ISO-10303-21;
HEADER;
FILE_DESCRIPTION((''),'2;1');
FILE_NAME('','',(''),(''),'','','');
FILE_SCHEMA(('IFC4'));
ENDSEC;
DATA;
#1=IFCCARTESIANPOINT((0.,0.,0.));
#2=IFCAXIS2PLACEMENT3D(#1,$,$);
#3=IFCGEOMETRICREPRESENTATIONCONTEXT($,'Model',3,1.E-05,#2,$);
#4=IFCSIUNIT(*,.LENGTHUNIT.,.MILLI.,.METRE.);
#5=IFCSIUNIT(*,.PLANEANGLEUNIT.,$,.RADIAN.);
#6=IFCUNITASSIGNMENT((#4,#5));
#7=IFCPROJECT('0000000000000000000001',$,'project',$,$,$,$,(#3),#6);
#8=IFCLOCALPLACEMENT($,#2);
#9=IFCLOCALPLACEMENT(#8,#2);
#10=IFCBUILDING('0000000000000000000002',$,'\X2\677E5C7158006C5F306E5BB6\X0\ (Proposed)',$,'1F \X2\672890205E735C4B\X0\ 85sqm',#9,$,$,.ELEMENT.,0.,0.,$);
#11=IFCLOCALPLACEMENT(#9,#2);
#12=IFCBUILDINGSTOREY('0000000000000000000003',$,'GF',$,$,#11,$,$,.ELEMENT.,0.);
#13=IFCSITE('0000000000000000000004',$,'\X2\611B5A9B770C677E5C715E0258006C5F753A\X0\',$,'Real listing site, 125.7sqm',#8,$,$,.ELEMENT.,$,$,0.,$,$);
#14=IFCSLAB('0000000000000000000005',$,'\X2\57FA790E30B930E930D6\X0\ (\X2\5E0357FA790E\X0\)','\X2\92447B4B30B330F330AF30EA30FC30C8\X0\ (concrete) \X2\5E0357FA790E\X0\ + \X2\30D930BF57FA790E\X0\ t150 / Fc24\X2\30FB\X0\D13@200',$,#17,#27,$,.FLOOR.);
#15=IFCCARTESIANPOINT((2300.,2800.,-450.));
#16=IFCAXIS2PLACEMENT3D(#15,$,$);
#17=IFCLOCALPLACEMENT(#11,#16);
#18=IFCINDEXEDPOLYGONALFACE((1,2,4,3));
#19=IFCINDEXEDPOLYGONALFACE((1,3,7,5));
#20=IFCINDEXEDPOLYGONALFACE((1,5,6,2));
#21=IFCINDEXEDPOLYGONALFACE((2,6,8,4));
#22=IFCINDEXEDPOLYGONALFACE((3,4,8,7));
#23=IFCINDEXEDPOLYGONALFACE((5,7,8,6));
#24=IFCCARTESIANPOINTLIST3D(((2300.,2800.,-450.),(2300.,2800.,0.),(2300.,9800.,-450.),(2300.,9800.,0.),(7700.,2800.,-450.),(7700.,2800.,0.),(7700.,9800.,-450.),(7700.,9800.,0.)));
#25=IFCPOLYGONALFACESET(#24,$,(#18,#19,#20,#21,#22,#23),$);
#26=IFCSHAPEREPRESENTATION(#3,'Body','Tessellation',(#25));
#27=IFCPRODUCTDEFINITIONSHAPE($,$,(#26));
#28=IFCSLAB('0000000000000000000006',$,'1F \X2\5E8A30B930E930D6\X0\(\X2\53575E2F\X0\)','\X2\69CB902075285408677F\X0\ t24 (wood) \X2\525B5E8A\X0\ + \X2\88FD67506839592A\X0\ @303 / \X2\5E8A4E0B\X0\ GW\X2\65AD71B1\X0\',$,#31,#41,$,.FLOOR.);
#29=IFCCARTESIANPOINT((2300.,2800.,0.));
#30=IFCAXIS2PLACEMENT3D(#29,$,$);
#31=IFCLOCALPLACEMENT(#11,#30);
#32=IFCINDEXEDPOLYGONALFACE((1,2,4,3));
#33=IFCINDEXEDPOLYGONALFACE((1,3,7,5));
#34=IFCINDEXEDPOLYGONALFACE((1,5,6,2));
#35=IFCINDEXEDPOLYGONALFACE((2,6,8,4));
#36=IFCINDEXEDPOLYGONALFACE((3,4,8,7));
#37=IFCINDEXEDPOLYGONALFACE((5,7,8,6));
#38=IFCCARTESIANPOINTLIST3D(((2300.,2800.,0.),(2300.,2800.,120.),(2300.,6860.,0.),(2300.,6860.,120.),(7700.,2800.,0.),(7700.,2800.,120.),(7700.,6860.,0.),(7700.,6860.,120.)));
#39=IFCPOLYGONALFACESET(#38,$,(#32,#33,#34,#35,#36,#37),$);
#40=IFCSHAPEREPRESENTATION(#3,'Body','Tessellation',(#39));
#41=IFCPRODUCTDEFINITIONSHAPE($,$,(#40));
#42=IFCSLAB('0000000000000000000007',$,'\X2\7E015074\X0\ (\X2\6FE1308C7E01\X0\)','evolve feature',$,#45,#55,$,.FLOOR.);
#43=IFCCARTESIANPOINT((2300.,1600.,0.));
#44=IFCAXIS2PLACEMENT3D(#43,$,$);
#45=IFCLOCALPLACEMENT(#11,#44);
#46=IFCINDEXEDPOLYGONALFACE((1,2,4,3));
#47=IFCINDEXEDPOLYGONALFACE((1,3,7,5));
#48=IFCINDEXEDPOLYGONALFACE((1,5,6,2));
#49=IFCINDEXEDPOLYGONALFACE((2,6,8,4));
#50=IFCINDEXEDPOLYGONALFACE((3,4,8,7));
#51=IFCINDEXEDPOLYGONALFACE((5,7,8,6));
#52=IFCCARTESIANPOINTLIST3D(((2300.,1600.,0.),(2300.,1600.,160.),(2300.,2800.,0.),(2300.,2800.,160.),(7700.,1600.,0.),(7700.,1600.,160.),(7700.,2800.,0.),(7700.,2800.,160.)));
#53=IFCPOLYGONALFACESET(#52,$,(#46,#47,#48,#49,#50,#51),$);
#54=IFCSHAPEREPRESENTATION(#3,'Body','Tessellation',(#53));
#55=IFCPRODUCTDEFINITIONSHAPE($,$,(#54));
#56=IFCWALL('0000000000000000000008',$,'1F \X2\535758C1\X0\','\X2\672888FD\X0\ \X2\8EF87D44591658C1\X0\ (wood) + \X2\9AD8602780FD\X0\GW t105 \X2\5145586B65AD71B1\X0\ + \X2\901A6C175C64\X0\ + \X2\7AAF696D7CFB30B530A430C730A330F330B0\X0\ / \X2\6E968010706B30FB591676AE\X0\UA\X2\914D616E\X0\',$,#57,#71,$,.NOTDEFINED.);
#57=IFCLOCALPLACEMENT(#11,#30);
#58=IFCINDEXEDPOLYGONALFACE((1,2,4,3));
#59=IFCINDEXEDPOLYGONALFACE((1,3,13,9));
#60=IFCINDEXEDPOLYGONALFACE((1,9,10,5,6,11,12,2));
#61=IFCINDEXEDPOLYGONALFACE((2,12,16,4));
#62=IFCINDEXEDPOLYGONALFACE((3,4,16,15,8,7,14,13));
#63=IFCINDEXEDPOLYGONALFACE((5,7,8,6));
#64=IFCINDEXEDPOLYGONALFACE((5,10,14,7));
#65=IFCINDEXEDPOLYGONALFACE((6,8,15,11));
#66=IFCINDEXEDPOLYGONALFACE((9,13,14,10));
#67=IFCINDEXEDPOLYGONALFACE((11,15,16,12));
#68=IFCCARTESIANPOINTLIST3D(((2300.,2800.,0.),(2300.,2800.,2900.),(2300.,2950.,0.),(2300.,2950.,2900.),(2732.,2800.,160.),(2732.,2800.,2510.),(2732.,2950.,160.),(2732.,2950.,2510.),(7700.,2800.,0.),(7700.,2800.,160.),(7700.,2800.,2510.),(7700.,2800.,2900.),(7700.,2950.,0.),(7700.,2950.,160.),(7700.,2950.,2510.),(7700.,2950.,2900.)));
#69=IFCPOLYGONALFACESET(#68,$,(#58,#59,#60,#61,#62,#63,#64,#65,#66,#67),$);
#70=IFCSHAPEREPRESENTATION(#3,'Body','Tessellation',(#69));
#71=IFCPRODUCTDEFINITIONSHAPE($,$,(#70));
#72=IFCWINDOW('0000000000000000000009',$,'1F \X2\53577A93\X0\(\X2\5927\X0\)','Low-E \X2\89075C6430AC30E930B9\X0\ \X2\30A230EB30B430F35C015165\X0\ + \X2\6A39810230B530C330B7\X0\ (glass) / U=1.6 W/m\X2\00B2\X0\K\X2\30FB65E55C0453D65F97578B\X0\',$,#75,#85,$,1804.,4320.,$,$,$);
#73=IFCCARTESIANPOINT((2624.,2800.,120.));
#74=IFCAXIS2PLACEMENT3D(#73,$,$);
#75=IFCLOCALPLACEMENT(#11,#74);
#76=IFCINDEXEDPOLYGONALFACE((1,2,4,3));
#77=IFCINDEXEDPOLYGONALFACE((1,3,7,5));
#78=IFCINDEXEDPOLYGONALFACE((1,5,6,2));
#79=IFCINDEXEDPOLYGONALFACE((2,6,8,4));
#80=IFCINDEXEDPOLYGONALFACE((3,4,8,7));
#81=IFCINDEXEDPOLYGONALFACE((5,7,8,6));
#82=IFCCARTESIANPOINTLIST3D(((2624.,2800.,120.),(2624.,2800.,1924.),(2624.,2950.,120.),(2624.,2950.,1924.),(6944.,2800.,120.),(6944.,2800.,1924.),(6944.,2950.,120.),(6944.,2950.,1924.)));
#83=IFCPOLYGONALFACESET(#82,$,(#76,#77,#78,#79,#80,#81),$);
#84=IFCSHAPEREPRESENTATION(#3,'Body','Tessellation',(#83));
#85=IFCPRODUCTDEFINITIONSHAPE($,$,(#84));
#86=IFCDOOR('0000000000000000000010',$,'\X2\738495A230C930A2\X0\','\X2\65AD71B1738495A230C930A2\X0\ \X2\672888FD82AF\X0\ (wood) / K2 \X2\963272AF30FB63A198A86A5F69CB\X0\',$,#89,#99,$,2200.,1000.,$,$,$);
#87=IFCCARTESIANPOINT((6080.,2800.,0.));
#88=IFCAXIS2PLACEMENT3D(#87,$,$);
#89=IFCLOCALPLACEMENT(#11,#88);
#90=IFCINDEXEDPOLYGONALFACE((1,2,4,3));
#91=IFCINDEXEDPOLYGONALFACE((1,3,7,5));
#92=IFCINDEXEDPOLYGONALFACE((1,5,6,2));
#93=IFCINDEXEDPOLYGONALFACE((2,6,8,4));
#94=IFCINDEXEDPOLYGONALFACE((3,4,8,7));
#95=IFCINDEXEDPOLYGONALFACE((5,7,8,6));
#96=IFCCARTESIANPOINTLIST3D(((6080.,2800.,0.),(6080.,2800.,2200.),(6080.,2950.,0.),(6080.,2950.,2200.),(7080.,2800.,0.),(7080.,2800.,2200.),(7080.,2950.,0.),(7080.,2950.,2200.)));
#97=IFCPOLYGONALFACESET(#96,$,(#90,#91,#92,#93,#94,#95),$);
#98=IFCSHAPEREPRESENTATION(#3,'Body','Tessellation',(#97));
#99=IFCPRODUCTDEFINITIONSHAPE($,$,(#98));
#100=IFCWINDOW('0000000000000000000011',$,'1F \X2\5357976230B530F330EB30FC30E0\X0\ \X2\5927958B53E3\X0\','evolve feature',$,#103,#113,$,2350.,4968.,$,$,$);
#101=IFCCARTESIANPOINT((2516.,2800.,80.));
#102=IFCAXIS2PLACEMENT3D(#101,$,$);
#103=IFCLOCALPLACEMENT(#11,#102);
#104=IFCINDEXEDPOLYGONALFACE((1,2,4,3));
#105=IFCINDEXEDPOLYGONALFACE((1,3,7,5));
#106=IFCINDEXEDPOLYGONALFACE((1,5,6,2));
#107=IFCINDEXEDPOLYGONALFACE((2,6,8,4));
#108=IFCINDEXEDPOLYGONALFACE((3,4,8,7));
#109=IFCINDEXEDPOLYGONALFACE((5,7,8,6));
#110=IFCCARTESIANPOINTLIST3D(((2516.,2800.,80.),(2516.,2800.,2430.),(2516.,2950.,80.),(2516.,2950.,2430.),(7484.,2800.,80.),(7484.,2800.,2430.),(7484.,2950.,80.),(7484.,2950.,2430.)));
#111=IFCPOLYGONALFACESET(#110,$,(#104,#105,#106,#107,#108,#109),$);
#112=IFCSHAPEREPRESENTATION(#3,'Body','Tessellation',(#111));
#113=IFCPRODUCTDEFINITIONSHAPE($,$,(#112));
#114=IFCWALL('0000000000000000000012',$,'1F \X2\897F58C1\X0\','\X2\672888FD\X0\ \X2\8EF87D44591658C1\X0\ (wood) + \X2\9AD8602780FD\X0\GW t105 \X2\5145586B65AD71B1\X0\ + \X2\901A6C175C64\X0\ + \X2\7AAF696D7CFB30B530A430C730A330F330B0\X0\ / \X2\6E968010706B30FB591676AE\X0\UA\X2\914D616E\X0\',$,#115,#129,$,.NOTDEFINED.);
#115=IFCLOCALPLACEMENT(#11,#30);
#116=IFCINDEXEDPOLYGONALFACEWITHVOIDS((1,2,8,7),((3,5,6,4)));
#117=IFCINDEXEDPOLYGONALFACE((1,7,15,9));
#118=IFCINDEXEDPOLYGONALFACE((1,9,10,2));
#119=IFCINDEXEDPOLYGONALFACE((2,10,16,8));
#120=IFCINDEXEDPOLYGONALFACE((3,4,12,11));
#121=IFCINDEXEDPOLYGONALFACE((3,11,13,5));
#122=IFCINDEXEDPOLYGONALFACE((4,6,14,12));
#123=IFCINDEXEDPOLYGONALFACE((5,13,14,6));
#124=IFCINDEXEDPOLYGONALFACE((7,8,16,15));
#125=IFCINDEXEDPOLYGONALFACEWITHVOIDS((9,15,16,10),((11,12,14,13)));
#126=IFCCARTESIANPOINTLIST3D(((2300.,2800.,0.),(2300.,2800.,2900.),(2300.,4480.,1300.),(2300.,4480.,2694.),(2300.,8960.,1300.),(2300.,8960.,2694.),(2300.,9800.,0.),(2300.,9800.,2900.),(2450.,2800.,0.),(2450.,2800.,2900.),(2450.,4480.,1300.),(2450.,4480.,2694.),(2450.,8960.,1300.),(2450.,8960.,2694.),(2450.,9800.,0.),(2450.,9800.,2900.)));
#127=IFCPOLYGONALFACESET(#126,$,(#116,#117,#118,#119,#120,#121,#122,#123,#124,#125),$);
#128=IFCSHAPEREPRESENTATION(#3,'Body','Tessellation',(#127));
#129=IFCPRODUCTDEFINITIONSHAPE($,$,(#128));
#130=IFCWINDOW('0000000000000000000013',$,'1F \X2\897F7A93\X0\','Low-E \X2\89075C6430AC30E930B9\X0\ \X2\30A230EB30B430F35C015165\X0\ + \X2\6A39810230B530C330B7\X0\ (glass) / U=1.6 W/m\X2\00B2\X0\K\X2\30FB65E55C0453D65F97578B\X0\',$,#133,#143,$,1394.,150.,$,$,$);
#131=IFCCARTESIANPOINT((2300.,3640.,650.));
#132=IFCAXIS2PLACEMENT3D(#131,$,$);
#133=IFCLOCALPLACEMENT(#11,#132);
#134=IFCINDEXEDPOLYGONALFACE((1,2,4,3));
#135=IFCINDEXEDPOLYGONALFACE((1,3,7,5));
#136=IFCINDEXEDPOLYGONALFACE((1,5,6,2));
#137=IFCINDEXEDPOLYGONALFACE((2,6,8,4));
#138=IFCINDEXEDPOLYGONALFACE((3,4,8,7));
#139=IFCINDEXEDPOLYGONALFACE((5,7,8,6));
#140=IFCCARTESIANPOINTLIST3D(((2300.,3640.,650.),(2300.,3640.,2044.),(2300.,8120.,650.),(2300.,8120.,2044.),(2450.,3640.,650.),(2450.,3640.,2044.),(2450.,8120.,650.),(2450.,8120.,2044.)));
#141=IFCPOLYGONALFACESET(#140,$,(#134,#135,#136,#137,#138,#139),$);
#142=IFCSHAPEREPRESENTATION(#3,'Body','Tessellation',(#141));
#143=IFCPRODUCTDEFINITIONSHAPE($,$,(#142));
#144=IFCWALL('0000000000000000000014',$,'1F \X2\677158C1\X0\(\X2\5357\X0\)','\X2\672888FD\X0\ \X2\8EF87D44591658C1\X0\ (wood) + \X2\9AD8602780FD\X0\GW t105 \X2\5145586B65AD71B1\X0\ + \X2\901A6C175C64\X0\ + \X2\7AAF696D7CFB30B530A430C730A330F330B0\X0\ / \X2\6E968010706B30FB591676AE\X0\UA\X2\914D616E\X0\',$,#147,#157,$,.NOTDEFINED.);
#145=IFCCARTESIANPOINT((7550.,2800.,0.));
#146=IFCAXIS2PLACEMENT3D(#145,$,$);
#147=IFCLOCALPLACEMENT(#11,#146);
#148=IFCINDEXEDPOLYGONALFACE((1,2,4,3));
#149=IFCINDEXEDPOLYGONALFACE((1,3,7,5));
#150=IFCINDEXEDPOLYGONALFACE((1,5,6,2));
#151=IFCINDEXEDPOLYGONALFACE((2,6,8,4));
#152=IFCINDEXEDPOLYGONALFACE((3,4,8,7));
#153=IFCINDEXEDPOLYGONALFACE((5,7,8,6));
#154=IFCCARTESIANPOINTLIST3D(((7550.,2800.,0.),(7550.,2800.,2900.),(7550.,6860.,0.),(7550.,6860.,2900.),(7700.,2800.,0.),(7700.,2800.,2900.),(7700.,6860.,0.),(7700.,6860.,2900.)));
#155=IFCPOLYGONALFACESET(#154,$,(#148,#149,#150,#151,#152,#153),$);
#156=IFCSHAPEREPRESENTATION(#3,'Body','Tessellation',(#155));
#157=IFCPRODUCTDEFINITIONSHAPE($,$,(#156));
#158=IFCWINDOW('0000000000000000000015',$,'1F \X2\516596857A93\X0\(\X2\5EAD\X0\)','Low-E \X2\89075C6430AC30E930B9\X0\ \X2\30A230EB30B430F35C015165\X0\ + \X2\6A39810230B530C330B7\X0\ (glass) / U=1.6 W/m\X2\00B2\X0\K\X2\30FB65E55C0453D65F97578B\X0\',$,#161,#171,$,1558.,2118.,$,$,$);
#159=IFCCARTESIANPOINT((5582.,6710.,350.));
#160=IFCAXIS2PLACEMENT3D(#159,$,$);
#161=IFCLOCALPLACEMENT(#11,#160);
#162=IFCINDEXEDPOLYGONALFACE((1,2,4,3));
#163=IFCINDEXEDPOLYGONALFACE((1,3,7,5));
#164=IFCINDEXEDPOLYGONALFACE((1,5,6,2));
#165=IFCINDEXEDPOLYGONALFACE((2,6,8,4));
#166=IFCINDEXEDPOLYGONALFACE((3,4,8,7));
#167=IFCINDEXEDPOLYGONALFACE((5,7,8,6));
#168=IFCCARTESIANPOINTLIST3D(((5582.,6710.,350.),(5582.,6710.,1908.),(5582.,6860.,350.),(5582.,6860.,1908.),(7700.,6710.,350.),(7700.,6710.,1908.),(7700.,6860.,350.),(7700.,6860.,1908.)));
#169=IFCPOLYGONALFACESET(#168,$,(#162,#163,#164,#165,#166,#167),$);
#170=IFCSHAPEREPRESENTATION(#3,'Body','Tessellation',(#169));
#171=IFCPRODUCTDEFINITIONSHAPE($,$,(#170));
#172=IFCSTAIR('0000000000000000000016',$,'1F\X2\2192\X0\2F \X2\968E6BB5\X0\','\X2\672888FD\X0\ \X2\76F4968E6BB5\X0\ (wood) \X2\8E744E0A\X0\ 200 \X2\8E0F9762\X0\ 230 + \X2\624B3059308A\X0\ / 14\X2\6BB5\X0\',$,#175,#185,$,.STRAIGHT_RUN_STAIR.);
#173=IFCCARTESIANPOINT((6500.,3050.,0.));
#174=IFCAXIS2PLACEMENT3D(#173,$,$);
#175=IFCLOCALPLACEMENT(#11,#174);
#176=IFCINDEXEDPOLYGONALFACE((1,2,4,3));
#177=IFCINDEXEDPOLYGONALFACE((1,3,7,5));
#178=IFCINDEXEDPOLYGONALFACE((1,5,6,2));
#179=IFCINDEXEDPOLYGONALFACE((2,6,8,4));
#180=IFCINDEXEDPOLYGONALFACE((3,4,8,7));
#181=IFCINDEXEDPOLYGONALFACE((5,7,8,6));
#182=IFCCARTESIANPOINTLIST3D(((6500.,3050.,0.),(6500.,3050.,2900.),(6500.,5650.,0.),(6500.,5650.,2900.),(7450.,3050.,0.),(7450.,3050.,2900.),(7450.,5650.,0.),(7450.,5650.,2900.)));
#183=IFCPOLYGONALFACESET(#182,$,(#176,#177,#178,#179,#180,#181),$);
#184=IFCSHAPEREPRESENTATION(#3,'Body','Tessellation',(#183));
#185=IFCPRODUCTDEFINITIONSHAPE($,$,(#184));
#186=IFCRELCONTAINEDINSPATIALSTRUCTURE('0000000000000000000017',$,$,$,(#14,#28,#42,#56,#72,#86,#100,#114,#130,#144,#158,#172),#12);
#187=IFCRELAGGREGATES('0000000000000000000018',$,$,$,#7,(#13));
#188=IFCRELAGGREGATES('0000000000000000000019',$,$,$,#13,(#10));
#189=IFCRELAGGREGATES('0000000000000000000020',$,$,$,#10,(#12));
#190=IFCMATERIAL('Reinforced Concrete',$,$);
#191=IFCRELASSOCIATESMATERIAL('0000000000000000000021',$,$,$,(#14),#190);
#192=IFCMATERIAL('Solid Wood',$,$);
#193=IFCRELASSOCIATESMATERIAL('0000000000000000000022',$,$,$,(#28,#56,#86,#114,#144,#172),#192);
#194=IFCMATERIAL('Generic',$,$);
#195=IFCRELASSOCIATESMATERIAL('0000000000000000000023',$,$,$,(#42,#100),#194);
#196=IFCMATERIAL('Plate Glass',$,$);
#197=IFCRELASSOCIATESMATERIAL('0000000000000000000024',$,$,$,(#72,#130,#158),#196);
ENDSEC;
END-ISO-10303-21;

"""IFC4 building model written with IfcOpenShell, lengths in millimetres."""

from ifc_helpers import new_model, si_unit, frame, frame_2d, origin, place, context, project, spatial, rectangle, extrude, material, element, fill, save


model = new_model("IFC4")

# Units and contexts
model_context = context("Model", 3, precision=1e-05, world=origin())
ifc_project = project(units=[si_unit("LENGTHUNIT", "METRE", prefix="MILLI"), si_unit("PLANEANGLEUNIT", "RADIAN")], contexts=[model_context])

# Site, building, storey
site_placement = place(None, origin())
site = spatial("IfcSite", under=ifc_project, at=site_placement, Name="愛媛県松山市堀江町", ObjectType="Real listing site, 125.7sqm", CompositionType="ELEMENT", RefElevation=0.0)
building_placement = place(site_placement, origin())
building = spatial("IfcBuilding", under=site, at=building_placement, Name="松山堀江の家 (Proposed)", ObjectType="1F 木造平屋 85sqm", CompositionType="ELEMENT", ElevationOfRefHeight=0.0, ElevationOfTerrain=0.0)
storey_placement = place(building_placement, origin())
storey = spatial("IfcBuildingStorey", under=building, at=storey_placement, Name="GF", CompositionType="ELEMENT", Elevation=0.0)

# Slabs
ifc_material_1 = material(Name="Reinforced Concrete")
slab_1_placement = place(storey_placement, frame((2300.0, 2800.0, -450.0)))
element("IfcSlab", 1, at=slab_1_placement, inside=storey, material=ifc_material_1, Name="基礎スラブ (布基礎)", Description="鉄筋コンクリート (concrete) 布基礎 + ベタ基礎 t150 / Fc24・D13@200", PredefinedType="FLOOR", context=model_context, shape_type="SweptSolid", body=[
    extrude(rectangle(XDim=5400.0, YDim=7000.0, at=frame_2d((2700.0, 3500.0))), frame((2300.0, 2800.0, -450.0)), (0.0, 0.0, 1.0), 450.0),
])
ifc_material_2 = material(Name="Solid Wood")
slab_2_placement = place(storey_placement, frame((2300.0, 2800.0, 0.0)))
element("IfcSlab", 2, at=slab_2_placement, inside=storey, material=ifc_material_2, Name="1F 床スラブ(南帯)", Description="構造用合板 t24 (wood) 剛床 + 製材根太 @303 / 床下 GW断熱", PredefinedType="FLOOR", context=model_context, shape_type="SweptSolid", body=[
    extrude(rectangle(XDim=5400.0, YDim=4060.0, at=frame_2d((2700.0, 2030.0))), frame((2300.0, 2800.0, 0.0)), (0.0, 0.0, 1.0), 120.0),
])
ifc_material_3 = material(Name="Generic")
slab_3_placement = place(storey_placement, frame((2300.0, 1600.0, 0.0)))
element("IfcSlab", 3, at=slab_3_placement, inside=storey, material=ifc_material_3, Name="縁側 (濡れ縁)", Description="evolve feature", PredefinedType="FLOOR", context=model_context, shape_type="SweptSolid", body=[
    extrude(rectangle(XDim=5400.0, YDim=1200.0, at=frame_2d((2700.0, 600.0))), frame((2300.0, 1600.0, 0.0)), (0.0, 0.0, 1.0), 160.0),
])

# Wall, openings, windows, door
wall_1_placement = place(storey_placement, frame((2300.0, 2800.0, 0.0)))
wall_1 = element("IfcWall", 4, at=wall_1_placement, inside=storey, material=ifc_material_2, Name="1F 南壁", Description="木製 軸組外壁 (wood) + 高性能GW t105 充填断熱 + 通気層 + 窯業系サイディング / 準耐火・外皮UA配慮", PredefinedType="NOTDEFINED", context=model_context, shape_type="SweptSolid", body=[
    extrude(rectangle(XDim=5400.0, YDim=150.0, at=frame_2d((2700.0, 75.0))), frame((2300.0, 2800.0, 0.0)), (0.0, 0.0, 1.0), 2900.0),
])
opening_1_placement = place(storey_placement, frame((2624.0, 2800.0, 120.0)))
opening_1 = element("IfcOpeningElement", 5, at=opening_1_placement, cuts=wall_1, PredefinedType="NOTDEFINED", context=model_context, shape_type="SweptSolid", body=[
    extrude(rectangle(XDim=4320.0, YDim=150.0, at=frame_2d((2160.0, 75.0))), frame((2624.0, 2800.0, 120.0)), (0.0, 0.0, 1.0), 1804.0),
])
opening_2_placement = place(storey_placement, frame((6080.0, 2800.0, 0.0)))
opening_2 = element("IfcOpeningElement", 6, at=opening_2_placement, cuts=wall_1, PredefinedType="NOTDEFINED", context=model_context, shape_type="SweptSolid", body=[
    extrude(rectangle(XDim=1000.0, YDim=150.0, at=frame_2d((500.0, 75.0))), frame((6080.0, 2800.0, 0.0)), (0.0, 0.0, 1.0), 2200.0),
])
opening_3_placement = place(storey_placement, frame((2516.0, 2800.0, 80.0)))
opening_3 = element("IfcOpeningElement", 7, at=opening_3_placement, cuts=wall_1, PredefinedType="NOTDEFINED", context=model_context, shape_type="SweptSolid", body=[
    extrude(rectangle(XDim=4968.0, YDim=150.0, at=frame_2d((2484.0, 75.0))), frame((2516.0, 2800.0, 80.0)), (0.0, 0.0, 1.0), 2350.0),
])
ifc_material_4 = material(Name="Plate Glass")
window_1_placement = place(storey_placement, frame((2624.0, 2800.0, 120.0)))
window_1 = element("IfcWindow", 8, at=window_1_placement, inside=storey, material=ifc_material_4, Name="1F 南窓(大)", Description="Low-E 複層ガラス アルゴン封入 + 樹脂サッシ (glass) / U=1.6 W/m²K・日射取得型", OverallHeight=1804.0, OverallWidth=4320.0, context=model_context, shape_type="SweptSolid", body=[
    extrude(rectangle(XDim=4320.0, YDim=150.0, at=frame_2d((2160.0, 75.0))), frame((2624.0, 2800.0, 120.0)), (0.0, 0.0, 1.0), 1804.0),
])
fill(opening_1, window_1)
door_1_placement = place(storey_placement, frame((6080.0, 2800.0, 0.0)))
door_1 = element("IfcDoor", 9, at=door_1_placement, inside=storey, material=ifc_material_2, Name="玄関ドア", Description="断熱玄関ドア 木製芯 (wood) / K2 防犯・採風機構", OverallHeight=2200.0, OverallWidth=1000.0, context=model_context, shape_type="SweptSolid", body=[
    extrude(rectangle(XDim=1000.0, YDim=150.0, at=frame_2d((500.0, 75.0))), frame((6080.0, 2800.0, 0.0)), (0.0, 0.0, 1.0), 2200.0),
])
fill(opening_2, door_1)
window_2_placement = place(storey_placement, frame((2516.0, 2800.0, 80.0)))
window_2 = element("IfcWindow", 10, at=window_2_placement, inside=storey, material=ifc_material_3, Name="1F 南面サンルーム 大開口", Description="evolve feature", OverallHeight=2350.0, OverallWidth=4968.0, context=model_context, shape_type="SweptSolid", body=[
    extrude(rectangle(XDim=4968.0, YDim=150.0, at=frame_2d((2484.0, 75.0))), frame((2516.0, 2800.0, 80.0)), (0.0, 0.0, 1.0), 2350.0),
])
fill(opening_3, window_2)

# Walls, openings, windows
wall_2_placement = place(storey_placement, frame((2300.0, 2800.0, 0.0)))
wall_2 = element("IfcWall", 11, at=wall_2_placement, inside=storey, material=ifc_material_2, Name="1F 西壁", Description="木製 軸組外壁 (wood) + 高性能GW t105 充填断熱 + 通気層 + 窯業系サイディング / 準耐火・外皮UA配慮", PredefinedType="NOTDEFINED", context=model_context, shape_type="SweptSolid", body=[
    extrude(rectangle(XDim=150.0, YDim=7000.0, at=frame_2d((75.0, 3500.0))), frame((2300.0, 2800.0, 0.0)), (0.0, 0.0, 1.0), 2900.0),
])
opening_4_placement = place(storey_placement, frame((2300.0, 3640.0, 650.0)))
opening_4 = element("IfcOpeningElement", 12, at=opening_4_placement, cuts=wall_2, PredefinedType="NOTDEFINED", context=model_context, shape_type="SweptSolid", body=[
    extrude(rectangle(XDim=150.0, YDim=4480.0, at=frame_2d((75.0, 2240.0))), frame((2300.0, 3640.0, 650.0)), (0.0, 0.0, 1.0), 1394.0),
])
window_3_placement = place(storey_placement, frame((2300.0, 3640.0, 650.0)))
window_3 = element("IfcWindow", 13, at=window_3_placement, inside=storey, material=ifc_material_4, Name="1F 西窓", Description="Low-E 複層ガラス アルゴン封入 + 樹脂サッシ (glass) / U=1.6 W/m²K・日射取得型", OverallHeight=1394.0, OverallWidth=150.0, context=model_context, shape_type="SweptSolid", body=[
    extrude(rectangle(XDim=150.0, YDim=4480.0, at=frame_2d((75.0, 2240.0))), frame((2300.0, 3640.0, 650.0)), (0.0, 0.0, 1.0), 1394.0),
])
fill(opening_4, window_3)
wall_3_placement = place(storey_placement, frame((7550.0, 2800.0, 0.0)))
wall_3 = element("IfcWall", 14, at=wall_3_placement, inside=storey, material=ifc_material_2, Name="1F 東壁(南)", Description="木製 軸組外壁 (wood) + 高性能GW t105 充填断熱 + 通気層 + 窯業系サイディング / 準耐火・外皮UA配慮", PredefinedType="NOTDEFINED", context=model_context, shape_type="SweptSolid", body=[
    extrude(rectangle(XDim=150.0, YDim=4060.0, at=frame_2d((75.0, 2030.0))), frame((7550.0, 2800.0, 0.0)), (0.0, 0.0, 1.0), 2900.0),
])
opening_5_placement = place(storey_placement, frame((5582.0, 6710.0, 350.0)))
opening_5 = element("IfcOpeningElement", 15, at=opening_5_placement, cuts=wall_3, PredefinedType="NOTDEFINED", context=model_context, shape_type="SweptSolid", body=[
    extrude(rectangle(XDim=2118.0, YDim=150.0, at=frame_2d((1059.0, 75.0))), frame((5582.0, 6710.0, 350.0)), (0.0, 0.0, 1.0), 1558.0),
])
window_4_placement = place(storey_placement, frame((5582.0, 6710.0, 350.0)))
window_4 = element("IfcWindow", 16, at=window_4_placement, inside=storey, material=ifc_material_4, Name="1F 入隅窓(庭)", Description="Low-E 複層ガラス アルゴン封入 + 樹脂サッシ (glass) / U=1.6 W/m²K・日射取得型", OverallHeight=1558.0, OverallWidth=2118.0, context=model_context, shape_type="SweptSolid", body=[
    extrude(rectangle(XDim=2118.0, YDim=150.0, at=frame_2d((1059.0, 75.0))), frame((5582.0, 6710.0, 350.0)), (0.0, 0.0, 1.0), 1558.0),
])
fill(opening_5, window_4)

# Stair
stair_placement = place(storey_placement, frame((6500.0, 3050.0, 0.0)))
element("IfcStair", 17, at=stair_placement, inside=storey, material=ifc_material_2, Name="1F→2F 階段", Description="木製 直階段 (wood) 蹴上 200 踏面 230 + 手すり / 14段", PredefinedType="STRAIGHT_RUN_STAIR", context=model_context, shape_type="SweptSolid", body=[
    extrude(rectangle(XDim=950.0, YDim=2600.0, at=frame_2d((475.0, 1300.0))), frame((6500.0, 3050.0, 0.0)), (0.0, 0.0, 1.0), 2900.0),
])

save(model, "model.ifc")
